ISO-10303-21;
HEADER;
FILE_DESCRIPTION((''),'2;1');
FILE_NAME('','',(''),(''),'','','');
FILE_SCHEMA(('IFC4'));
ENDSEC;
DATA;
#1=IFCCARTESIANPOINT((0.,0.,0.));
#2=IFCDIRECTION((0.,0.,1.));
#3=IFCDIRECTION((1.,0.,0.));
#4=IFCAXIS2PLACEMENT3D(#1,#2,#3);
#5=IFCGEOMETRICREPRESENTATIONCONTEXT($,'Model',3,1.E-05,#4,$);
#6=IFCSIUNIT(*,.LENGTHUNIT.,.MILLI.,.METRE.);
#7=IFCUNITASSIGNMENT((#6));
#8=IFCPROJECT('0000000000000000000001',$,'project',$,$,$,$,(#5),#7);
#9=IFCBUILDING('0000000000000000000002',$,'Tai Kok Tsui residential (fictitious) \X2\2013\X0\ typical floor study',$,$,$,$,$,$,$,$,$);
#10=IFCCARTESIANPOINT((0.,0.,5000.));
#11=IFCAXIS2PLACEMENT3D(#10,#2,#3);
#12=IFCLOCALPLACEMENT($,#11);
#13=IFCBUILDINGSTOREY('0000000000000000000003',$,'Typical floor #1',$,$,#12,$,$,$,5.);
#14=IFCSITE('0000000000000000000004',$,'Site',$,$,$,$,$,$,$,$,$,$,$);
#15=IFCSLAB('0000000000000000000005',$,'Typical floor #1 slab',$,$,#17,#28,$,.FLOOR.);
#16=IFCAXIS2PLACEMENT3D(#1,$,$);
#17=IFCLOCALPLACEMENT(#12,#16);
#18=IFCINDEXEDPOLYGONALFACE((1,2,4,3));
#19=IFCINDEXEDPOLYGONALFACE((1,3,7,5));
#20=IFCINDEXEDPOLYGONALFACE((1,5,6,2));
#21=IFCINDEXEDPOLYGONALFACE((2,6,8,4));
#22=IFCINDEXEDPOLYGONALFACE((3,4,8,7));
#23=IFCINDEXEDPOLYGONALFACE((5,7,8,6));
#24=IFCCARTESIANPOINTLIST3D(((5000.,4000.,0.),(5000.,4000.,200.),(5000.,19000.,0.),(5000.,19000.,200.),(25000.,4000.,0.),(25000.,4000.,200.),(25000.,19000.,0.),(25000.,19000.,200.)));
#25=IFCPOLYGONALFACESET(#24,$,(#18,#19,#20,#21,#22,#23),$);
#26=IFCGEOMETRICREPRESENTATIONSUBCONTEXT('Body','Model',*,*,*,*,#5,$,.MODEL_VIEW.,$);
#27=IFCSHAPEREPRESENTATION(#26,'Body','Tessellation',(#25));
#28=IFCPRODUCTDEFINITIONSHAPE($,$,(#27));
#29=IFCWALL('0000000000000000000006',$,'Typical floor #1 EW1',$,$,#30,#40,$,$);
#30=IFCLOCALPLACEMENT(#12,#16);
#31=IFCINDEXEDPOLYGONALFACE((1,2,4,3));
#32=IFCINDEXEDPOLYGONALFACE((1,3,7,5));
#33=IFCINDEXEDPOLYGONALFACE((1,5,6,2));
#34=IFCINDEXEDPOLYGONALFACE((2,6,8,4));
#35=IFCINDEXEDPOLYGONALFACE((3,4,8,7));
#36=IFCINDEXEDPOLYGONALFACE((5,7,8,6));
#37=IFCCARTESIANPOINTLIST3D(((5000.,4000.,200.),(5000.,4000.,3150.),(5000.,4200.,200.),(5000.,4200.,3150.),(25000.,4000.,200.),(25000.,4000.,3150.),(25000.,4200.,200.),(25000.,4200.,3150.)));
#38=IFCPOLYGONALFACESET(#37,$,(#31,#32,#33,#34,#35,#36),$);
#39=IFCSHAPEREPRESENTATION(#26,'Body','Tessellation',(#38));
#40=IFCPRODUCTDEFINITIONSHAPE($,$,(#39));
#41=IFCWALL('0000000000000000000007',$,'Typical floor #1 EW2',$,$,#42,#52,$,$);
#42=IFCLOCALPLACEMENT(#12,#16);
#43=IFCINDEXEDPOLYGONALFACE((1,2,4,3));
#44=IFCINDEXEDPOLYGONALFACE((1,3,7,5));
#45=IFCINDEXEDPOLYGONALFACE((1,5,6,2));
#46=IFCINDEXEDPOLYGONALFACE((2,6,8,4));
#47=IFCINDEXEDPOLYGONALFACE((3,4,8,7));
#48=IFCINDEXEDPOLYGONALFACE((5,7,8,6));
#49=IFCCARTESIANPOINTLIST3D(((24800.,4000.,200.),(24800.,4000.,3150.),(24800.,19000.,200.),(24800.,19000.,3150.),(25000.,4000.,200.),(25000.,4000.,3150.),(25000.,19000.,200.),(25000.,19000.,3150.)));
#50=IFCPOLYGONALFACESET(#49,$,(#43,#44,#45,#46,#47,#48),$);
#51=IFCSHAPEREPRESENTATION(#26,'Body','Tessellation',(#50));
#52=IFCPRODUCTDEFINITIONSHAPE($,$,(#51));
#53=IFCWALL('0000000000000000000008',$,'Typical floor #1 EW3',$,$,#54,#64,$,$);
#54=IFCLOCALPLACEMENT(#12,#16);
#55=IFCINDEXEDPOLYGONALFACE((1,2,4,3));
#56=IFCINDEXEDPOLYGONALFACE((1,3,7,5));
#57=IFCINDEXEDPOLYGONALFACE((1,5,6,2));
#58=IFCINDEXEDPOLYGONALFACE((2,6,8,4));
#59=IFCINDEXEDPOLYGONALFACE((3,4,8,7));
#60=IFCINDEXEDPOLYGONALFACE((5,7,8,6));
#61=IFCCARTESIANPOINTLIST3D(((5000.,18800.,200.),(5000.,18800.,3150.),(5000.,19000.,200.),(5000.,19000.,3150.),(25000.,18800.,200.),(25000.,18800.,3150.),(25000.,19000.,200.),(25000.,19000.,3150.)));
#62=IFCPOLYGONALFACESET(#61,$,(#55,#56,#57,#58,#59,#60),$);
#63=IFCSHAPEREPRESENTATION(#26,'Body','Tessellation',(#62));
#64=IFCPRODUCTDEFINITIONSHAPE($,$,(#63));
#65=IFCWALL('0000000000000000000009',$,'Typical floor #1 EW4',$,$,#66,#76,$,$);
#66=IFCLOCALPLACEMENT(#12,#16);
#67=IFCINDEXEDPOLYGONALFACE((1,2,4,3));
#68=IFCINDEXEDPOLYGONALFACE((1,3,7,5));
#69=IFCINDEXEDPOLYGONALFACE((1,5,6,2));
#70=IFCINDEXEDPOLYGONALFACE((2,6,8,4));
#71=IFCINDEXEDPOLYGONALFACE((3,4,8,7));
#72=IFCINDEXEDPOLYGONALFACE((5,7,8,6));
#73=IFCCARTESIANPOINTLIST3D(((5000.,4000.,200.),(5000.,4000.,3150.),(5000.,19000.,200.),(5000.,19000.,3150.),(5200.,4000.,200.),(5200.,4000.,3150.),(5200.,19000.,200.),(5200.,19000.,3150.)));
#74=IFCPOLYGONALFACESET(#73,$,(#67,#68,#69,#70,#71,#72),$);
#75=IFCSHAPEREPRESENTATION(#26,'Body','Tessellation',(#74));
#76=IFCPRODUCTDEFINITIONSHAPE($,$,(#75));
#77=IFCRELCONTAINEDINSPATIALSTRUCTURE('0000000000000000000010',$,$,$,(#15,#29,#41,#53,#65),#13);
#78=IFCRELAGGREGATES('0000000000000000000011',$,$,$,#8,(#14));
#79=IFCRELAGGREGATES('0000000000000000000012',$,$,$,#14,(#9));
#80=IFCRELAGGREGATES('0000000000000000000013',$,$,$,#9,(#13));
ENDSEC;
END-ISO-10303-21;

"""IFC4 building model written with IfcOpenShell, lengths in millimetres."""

from ifc_helpers import new_model, si_unit, frame, origin_with_axes, place, context, subcontext, project, spatial, indexed_curve, outline, extrude, element, save


model = new_model("IFC4")

# Units and contexts
model_context = context("Model", 3, precision=1e-05, world=origin_with_axes())
body_context = subcontext(model_context, "Body", "Model", "MODEL_VIEW")
ifc_project = project(units=[si_unit("LENGTHUNIT", "METRE", prefix="MILLI")], contexts=[model_context])

# Site, building, storey
site = spatial("IfcSite", under=ifc_project, Name="Site")
building = spatial("IfcBuilding", under=site, Name="Tai Kok Tsui residential (fictitious) – typical floor study")
storey_placement = place(None, frame((0.0, 0.0, 5000.0), z_axis=(0.0, 0.0, 1.0), x_axis=(1.0, 0.0, 0.0)))
storey = spatial("IfcBuildingStorey", under=building, at=storey_placement, Name="Typical floor #1", Elevation=5.0)

# Slab
slab_placement = place(storey_placement, origin_with_axes())
element("IfcSlab", 1, at=slab_placement, inside=storey, Name="Typical floor #1 slab", PredefinedType="FLOOR", context=body_context, shape_type="SweptSolid", body=[
    extrude(outline(indexed_curve([(5000.0, 4000.0), (25000.0, 4000.0), (25000.0, 19000.0), (5000.0, 19000.0)])), None, (0.0, 0.0, 1.0), 200.0),
])

# Walls
wall_1_placement = place(storey_placement, frame((5000.0, 4000.0, 200.0), z_axis=(0.0, 0.0, 1.0), x_axis=(1.0, 0.0, 0.0)))
element("IfcWall", 2, at=wall_1_placement, inside=storey, Name="Typical floor #1 EW1", context=body_context, shape_type="SweptSolid", body=[
    extrude(outline(indexed_curve([(0.0, 0.0), (0.0, 200.0), (20000.0, 200.0), (20000.0, 0.0), (0.0, 0.0)], self_intersect=False)), origin_with_axes(), (0.0, 0.0, 1.0), 2950.0),
])
wall_2_placement = place(storey_placement, frame((25000.0, 4000.0, 200.0), z_axis=(0.0, 0.0, 1.0), x_axis=(0.0, 1.0, 0.0)))
element("IfcWall", 3, at=wall_2_placement, inside=storey, Name="Typical floor #1 EW2", context=body_context, shape_type="SweptSolid", body=[
    extrude(outline(indexed_curve([(0.0, 0.0), (0.0, 200.0), (15000.0, 200.0), (15000.0, 0.0), (0.0, 0.0)], self_intersect=False)), origin_with_axes(), (0.0, 0.0, 1.0), 2950.0),
])
wall_3_placement = place(storey_placement, frame((25000.0, 19000.0, 200.0), z_axis=(0.0, 0.0, 1.0), x_axis=(-1.0, 0.0, 0.0)))
element("IfcWall", 4, at=wall_3_placement, inside=storey, Name="Typical floor #1 EW3", context=body_context, shape_type="SweptSolid", body=[
    extrude(outline(indexed_curve([(0.0, 0.0), (0.0, 200.0), (20000.0, 200.0), (20000.0, 0.0), (0.0, 0.0)], self_intersect=False)), origin_with_axes(), (0.0, 0.0, 1.0), 2950.0),
])
wall_4_placement = place(storey_placement, frame((5000.0, 19000.0, 200.0), z_axis=(0.0, 0.0, 1.0), x_axis=(0.0, -1.0, 0.0)))
element("IfcWall", 5, at=wall_4_placement, inside=storey, Name="Typical floor #1 EW4", context=body_context, shape_type="SweptSolid", body=[
    extrude(outline(indexed_curve([(0.0, 0.0), (0.0, 200.0), (15000.0, 200.0), (15000.0, 0.0), (0.0, 0.0)], self_intersect=False)), origin_with_axes(), (0.0, 0.0, 1.0), 2950.0),
])

save(model, "model.ifc")
